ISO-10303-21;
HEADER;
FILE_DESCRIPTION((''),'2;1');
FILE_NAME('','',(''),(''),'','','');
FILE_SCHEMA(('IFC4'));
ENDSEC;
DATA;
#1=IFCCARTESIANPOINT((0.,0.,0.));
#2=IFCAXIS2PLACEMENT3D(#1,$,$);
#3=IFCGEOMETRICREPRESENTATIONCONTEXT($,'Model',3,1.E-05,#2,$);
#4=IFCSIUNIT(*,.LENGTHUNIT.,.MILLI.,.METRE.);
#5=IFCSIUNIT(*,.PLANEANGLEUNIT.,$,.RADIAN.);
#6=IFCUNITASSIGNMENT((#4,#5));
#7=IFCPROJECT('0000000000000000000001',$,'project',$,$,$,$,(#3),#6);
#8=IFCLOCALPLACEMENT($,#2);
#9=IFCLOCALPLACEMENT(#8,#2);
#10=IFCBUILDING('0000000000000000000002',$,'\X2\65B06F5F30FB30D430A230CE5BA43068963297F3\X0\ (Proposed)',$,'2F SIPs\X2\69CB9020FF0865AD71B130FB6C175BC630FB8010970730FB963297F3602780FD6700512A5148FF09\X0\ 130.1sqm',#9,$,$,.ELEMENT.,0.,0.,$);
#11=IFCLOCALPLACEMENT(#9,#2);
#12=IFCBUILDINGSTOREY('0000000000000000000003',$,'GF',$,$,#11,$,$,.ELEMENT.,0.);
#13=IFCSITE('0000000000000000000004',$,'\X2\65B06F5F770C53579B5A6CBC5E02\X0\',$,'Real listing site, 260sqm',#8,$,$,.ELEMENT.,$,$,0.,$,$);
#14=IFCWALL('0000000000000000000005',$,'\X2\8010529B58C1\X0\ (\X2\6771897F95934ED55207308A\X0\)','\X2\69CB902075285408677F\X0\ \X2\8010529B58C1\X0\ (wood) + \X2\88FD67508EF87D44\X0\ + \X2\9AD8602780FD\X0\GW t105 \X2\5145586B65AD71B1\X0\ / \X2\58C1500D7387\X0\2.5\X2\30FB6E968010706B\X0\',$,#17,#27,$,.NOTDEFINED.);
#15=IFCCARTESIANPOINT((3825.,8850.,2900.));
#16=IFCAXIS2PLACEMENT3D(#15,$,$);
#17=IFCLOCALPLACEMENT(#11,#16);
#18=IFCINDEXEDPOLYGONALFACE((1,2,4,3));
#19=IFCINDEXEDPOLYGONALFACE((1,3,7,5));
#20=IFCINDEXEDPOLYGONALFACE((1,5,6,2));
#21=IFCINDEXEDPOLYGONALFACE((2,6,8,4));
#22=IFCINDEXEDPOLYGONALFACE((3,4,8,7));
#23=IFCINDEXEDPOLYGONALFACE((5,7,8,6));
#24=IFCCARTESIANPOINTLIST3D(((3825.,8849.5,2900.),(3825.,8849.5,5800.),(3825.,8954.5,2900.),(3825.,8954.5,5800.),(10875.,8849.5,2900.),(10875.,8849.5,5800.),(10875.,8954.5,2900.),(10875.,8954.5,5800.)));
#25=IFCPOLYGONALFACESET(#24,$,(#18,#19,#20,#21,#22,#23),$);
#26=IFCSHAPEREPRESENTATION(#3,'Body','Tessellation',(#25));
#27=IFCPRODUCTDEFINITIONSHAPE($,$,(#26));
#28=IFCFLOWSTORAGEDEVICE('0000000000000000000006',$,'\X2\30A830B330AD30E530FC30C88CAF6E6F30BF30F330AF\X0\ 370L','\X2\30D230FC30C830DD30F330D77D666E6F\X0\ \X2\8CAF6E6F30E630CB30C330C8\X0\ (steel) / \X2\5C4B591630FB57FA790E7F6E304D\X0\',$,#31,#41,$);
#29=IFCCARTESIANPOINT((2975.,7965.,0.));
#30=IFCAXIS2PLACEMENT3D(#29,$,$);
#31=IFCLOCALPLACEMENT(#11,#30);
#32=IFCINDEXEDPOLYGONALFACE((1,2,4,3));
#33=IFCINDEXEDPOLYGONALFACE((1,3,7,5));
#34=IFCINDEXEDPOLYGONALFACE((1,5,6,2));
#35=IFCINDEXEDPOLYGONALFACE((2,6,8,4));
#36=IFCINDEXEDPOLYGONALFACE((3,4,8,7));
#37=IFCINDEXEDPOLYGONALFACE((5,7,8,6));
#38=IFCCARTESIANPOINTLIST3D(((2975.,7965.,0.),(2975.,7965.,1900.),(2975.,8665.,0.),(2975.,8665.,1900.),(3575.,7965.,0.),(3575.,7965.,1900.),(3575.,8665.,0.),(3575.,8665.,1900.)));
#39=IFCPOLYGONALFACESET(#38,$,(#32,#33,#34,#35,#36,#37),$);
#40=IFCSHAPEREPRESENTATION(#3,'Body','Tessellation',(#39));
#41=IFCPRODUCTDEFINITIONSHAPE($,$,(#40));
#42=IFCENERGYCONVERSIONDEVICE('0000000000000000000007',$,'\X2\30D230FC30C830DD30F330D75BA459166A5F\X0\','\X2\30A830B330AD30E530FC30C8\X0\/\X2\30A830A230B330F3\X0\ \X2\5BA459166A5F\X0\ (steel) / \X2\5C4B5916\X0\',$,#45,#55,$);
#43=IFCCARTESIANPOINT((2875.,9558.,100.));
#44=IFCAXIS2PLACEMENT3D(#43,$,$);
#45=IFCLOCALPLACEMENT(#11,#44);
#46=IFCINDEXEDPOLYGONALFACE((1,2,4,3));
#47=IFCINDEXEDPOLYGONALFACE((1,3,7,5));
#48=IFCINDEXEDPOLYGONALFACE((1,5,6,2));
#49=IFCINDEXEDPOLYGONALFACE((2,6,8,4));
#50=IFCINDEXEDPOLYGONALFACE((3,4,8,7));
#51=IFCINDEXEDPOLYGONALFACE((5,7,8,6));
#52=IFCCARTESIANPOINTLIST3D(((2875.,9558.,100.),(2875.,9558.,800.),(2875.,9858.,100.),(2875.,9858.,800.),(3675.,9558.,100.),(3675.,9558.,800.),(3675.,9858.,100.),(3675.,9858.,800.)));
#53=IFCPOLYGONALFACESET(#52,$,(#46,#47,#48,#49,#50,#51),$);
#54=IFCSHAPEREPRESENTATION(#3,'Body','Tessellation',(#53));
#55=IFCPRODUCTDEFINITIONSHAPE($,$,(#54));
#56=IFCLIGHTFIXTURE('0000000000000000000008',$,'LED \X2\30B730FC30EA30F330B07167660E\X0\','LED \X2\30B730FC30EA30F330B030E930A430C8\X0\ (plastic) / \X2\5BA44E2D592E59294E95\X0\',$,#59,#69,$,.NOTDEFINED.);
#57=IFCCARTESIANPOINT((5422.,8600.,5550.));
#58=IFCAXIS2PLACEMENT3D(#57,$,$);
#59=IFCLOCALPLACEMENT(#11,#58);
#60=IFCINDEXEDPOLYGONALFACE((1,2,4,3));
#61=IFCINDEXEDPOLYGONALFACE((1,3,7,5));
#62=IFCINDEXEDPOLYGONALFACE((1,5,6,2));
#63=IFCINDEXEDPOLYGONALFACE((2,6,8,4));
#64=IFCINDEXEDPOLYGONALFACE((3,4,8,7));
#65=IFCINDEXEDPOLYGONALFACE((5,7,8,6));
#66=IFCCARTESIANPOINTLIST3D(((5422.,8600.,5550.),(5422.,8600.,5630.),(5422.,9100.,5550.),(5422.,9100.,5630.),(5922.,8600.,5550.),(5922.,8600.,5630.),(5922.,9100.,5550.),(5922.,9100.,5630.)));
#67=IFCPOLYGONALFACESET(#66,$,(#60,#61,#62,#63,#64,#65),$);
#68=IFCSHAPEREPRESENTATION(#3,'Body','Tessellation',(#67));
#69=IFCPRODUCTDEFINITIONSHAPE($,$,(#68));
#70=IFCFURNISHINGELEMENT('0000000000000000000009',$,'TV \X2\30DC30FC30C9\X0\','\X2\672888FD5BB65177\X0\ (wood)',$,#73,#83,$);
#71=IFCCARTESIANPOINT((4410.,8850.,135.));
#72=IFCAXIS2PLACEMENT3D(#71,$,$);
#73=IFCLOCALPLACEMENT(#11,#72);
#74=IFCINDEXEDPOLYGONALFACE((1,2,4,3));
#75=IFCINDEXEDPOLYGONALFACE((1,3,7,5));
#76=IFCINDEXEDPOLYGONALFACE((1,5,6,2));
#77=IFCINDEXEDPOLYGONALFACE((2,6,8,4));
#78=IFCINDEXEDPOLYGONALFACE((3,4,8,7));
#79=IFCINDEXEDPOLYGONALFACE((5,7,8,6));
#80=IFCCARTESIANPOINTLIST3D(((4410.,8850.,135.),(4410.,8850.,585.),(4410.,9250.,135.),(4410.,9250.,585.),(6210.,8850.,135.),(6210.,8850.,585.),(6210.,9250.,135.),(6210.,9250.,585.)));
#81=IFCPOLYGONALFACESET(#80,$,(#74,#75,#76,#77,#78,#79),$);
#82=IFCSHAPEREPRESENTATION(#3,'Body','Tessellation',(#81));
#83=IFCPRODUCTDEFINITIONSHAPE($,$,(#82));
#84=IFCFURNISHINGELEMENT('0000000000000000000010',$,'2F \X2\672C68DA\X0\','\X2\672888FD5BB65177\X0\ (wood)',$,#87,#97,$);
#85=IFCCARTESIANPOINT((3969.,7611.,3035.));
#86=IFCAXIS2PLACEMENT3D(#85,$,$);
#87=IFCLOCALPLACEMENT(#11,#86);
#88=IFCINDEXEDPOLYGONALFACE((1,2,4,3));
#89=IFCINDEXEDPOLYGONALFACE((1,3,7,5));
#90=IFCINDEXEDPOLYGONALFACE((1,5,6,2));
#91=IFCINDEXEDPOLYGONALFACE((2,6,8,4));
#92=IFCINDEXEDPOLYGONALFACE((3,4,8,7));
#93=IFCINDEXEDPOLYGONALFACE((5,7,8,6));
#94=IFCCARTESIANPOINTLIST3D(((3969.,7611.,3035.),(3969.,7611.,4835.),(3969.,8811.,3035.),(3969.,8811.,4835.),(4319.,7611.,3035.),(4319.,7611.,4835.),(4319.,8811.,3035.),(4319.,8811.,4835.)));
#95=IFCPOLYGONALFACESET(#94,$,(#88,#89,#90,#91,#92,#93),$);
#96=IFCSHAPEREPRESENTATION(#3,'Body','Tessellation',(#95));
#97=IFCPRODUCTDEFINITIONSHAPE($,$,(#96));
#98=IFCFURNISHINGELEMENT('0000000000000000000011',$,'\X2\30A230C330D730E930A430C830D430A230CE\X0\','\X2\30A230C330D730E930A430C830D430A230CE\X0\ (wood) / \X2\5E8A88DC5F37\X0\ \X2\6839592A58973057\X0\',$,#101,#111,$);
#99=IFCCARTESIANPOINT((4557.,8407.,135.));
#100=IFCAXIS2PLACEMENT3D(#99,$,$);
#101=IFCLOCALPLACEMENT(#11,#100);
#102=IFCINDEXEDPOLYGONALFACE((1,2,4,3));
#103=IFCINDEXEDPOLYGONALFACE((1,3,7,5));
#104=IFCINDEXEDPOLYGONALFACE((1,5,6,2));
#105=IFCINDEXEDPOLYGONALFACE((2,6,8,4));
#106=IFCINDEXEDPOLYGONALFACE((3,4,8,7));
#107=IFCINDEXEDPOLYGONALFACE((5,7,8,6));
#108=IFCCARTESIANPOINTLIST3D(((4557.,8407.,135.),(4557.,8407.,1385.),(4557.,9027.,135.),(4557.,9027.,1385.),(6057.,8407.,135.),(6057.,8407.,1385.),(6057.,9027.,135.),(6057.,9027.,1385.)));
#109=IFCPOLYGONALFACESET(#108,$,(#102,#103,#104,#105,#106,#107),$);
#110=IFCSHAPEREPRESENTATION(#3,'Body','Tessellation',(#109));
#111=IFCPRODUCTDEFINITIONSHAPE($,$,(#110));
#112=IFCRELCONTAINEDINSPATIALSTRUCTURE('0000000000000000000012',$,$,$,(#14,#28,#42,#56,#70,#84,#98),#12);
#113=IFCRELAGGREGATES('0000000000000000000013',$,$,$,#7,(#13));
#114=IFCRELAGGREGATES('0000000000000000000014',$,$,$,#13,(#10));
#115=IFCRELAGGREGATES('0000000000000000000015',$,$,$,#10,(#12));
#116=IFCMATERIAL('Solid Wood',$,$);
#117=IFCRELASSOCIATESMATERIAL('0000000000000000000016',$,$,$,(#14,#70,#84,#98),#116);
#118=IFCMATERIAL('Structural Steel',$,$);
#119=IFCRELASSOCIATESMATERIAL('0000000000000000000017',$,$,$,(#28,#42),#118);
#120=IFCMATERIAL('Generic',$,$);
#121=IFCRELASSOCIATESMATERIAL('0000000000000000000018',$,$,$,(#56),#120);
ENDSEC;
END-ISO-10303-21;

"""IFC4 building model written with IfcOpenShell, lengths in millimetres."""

from ifc_helpers import new_model, si_unit, frame, frame_2d, origin, place, context, project, spatial, rectangle, extrude, material, element, save


model = new_model("IFC4")

# Units and contexts
model_context = context("Model", 3, precision=1e-05, world=origin())
ifc_project = project(units=[si_unit("LENGTHUNIT", "METRE", prefix="MILLI"), si_unit("PLANEANGLEUNIT", "RADIAN")], contexts=[model_context])

# Site, building, storey
site_placement = place(None, origin())
site = spatial("IfcSite", under=ifc_project, at=site_placement, Name="新潟県南魚沼市", ObjectType="Real listing site, 260sqm", CompositionType="ELEMENT", RefElevation=0.0)
building_placement = place(site_placement, origin())
building = spatial("IfcBuilding", under=site, at=building_placement, Name="新潟・ピアノ室と防音 (Proposed)", ObjectType="2F SIPs構造（断熱・気密・耐震・防音性能最優先） 130.1sqm", CompositionType="ELEMENT", ElevationOfRefHeight=0.0, ElevationOfTerrain=0.0)
storey_placement = place(building_placement, origin())
storey = spatial("IfcBuildingStorey", under=building, at=storey_placement, Name="GF", CompositionType="ELEMENT", Elevation=0.0)

# Shared definitions
ifc_material_1 = material(Name="Solid Wood")

# Wall
wall_1_placement = place(storey_placement, frame((3825.0, 8850.0, 2900.0)))
element("IfcWall", 1, at=wall_1_placement, inside=storey, material=ifc_material_1, Name="耐力壁 (東西間仕切り)", Description="構造用合板 耐力壁 (wood) + 製材軸組 + 高性能GW t105 充填断熱 / 壁倍率2.5・準耐火", PredefinedType="NOTDEFINED", context=model_context, shape_type="SweptSolid", body=[
    extrude(rectangle(XDim=7050.0, YDim=105.0, at=frame_2d((3525.0, 52.0))), frame((3825.0, 8850.0, 2900.0)), (0.0, 0.0, 1.0), 2900.0),
])

# Flow storage device
ifc_material_2 = material(Name="Structural Steel")
flow_storage_device_placement = place(storey_placement, frame((2975.0, 7965.0, 0.0)))
element("IfcFlowStorageDevice", 2, at=flow_storage_device_placement, inside=storey, material=ifc_material_2, Name="エコキュート貯湯タンク 370L", Description="ヒートポンプ給湯 貯湯ユニット (steel) / 屋外・基礎置き", context=model_context, shape_type="SweptSolid", body=[
    extrude(rectangle(XDim=600.0, YDim=700.0, at=frame_2d((300.0, 350.0))), frame((2975.0, 7965.0, 0.0)), (0.0, 0.0, 1.0), 1900.0),
])

# Energy conversion device
energy_conversion_device_placement = place(storey_placement, frame((2875.0, 9558.0, 100.0)))
element("IfcEnergyConversionDevice", 3, at=energy_conversion_device_placement, inside=storey, material=ifc_material_2, Name="ヒートポンプ室外機", Description="エコキュート/エアコン 室外機 (steel) / 屋外", context=model_context, shape_type="SweptSolid", body=[
    extrude(rectangle(XDim=800.0, YDim=300.0, at=frame_2d((400.0, 150.0))), frame((2875.0, 9558.0, 100.0)), (0.0, 0.0, 1.0), 700.0),
])

# Light fixture
ifc_material_3 = material(Name="Generic")
light_fixture_placement = place(storey_placement, frame((5422.0, 8600.0, 5550.0)))
element("IfcLightFixture", 4, at=light_fixture_placement, inside=storey, material=ifc_material_3, Name="LED シーリング照明", Description="LED シーリングライト (plastic) / 室中央天井", PredefinedType="NOTDEFINED", context=model_context, shape_type="SweptSolid", body=[
    extrude(rectangle(XDim=500.0, YDim=500.0, at=frame_2d((250.0, 250.0))), frame((5422.0, 8600.0, 5550.0)), (0.0, 0.0, 1.0), 80.0),
])

# Furnishing elements
furnishing_1_placement = place(storey_placement, frame((4410.0, 8850.0, 135.0)))
element("IfcFurnishingElement", 5, at=furnishing_1_placement, inside=storey, material=ifc_material_1, Name="TV ボード", Description="木製家具 (wood)", context=model_context, shape_type="SweptSolid", body=[
    extrude(rectangle(XDim=1800.0, YDim=400.0, at=frame_2d((900.0, 200.0))), frame((4410.0, 8850.0, 135.0)), (0.0, 0.0, 1.0), 450.0),
])
furnishing_2_placement = place(storey_placement, frame((3969.0, 7611.0, 3035.0)))
element("IfcFurnishingElement", 6, at=furnishing_2_placement, inside=storey, material=ifc_material_1, Name="2F 本棚", Description="木製家具 (wood)", context=model_context, shape_type="SweptSolid", body=[
    extrude(rectangle(XDim=350.0, YDim=1200.0, at=frame_2d((175.0, 600.0))), frame((3969.0, 7611.0, 3035.0)), (0.0, 0.0, 1.0), 1800.0),
])
furnishing_3_placement = place(storey_placement, frame((4557.0, 8407.0, 135.0)))
element("IfcFurnishingElement", 7, at=furnishing_3_placement, inside=storey, material=ifc_material_1, Name="アップライトピアノ", Description="アップライトピアノ (wood) / 床補強 根太増し", context=model_context, shape_type="SweptSolid", body=[
    extrude(rectangle(XDim=1500.0, YDim=620.0, at=frame_2d((750.0, 310.0))), frame((4557.0, 8407.0, 135.0)), (0.0, 0.0, 1.0), 1250.0),
])

save(model, "model.ifc")
